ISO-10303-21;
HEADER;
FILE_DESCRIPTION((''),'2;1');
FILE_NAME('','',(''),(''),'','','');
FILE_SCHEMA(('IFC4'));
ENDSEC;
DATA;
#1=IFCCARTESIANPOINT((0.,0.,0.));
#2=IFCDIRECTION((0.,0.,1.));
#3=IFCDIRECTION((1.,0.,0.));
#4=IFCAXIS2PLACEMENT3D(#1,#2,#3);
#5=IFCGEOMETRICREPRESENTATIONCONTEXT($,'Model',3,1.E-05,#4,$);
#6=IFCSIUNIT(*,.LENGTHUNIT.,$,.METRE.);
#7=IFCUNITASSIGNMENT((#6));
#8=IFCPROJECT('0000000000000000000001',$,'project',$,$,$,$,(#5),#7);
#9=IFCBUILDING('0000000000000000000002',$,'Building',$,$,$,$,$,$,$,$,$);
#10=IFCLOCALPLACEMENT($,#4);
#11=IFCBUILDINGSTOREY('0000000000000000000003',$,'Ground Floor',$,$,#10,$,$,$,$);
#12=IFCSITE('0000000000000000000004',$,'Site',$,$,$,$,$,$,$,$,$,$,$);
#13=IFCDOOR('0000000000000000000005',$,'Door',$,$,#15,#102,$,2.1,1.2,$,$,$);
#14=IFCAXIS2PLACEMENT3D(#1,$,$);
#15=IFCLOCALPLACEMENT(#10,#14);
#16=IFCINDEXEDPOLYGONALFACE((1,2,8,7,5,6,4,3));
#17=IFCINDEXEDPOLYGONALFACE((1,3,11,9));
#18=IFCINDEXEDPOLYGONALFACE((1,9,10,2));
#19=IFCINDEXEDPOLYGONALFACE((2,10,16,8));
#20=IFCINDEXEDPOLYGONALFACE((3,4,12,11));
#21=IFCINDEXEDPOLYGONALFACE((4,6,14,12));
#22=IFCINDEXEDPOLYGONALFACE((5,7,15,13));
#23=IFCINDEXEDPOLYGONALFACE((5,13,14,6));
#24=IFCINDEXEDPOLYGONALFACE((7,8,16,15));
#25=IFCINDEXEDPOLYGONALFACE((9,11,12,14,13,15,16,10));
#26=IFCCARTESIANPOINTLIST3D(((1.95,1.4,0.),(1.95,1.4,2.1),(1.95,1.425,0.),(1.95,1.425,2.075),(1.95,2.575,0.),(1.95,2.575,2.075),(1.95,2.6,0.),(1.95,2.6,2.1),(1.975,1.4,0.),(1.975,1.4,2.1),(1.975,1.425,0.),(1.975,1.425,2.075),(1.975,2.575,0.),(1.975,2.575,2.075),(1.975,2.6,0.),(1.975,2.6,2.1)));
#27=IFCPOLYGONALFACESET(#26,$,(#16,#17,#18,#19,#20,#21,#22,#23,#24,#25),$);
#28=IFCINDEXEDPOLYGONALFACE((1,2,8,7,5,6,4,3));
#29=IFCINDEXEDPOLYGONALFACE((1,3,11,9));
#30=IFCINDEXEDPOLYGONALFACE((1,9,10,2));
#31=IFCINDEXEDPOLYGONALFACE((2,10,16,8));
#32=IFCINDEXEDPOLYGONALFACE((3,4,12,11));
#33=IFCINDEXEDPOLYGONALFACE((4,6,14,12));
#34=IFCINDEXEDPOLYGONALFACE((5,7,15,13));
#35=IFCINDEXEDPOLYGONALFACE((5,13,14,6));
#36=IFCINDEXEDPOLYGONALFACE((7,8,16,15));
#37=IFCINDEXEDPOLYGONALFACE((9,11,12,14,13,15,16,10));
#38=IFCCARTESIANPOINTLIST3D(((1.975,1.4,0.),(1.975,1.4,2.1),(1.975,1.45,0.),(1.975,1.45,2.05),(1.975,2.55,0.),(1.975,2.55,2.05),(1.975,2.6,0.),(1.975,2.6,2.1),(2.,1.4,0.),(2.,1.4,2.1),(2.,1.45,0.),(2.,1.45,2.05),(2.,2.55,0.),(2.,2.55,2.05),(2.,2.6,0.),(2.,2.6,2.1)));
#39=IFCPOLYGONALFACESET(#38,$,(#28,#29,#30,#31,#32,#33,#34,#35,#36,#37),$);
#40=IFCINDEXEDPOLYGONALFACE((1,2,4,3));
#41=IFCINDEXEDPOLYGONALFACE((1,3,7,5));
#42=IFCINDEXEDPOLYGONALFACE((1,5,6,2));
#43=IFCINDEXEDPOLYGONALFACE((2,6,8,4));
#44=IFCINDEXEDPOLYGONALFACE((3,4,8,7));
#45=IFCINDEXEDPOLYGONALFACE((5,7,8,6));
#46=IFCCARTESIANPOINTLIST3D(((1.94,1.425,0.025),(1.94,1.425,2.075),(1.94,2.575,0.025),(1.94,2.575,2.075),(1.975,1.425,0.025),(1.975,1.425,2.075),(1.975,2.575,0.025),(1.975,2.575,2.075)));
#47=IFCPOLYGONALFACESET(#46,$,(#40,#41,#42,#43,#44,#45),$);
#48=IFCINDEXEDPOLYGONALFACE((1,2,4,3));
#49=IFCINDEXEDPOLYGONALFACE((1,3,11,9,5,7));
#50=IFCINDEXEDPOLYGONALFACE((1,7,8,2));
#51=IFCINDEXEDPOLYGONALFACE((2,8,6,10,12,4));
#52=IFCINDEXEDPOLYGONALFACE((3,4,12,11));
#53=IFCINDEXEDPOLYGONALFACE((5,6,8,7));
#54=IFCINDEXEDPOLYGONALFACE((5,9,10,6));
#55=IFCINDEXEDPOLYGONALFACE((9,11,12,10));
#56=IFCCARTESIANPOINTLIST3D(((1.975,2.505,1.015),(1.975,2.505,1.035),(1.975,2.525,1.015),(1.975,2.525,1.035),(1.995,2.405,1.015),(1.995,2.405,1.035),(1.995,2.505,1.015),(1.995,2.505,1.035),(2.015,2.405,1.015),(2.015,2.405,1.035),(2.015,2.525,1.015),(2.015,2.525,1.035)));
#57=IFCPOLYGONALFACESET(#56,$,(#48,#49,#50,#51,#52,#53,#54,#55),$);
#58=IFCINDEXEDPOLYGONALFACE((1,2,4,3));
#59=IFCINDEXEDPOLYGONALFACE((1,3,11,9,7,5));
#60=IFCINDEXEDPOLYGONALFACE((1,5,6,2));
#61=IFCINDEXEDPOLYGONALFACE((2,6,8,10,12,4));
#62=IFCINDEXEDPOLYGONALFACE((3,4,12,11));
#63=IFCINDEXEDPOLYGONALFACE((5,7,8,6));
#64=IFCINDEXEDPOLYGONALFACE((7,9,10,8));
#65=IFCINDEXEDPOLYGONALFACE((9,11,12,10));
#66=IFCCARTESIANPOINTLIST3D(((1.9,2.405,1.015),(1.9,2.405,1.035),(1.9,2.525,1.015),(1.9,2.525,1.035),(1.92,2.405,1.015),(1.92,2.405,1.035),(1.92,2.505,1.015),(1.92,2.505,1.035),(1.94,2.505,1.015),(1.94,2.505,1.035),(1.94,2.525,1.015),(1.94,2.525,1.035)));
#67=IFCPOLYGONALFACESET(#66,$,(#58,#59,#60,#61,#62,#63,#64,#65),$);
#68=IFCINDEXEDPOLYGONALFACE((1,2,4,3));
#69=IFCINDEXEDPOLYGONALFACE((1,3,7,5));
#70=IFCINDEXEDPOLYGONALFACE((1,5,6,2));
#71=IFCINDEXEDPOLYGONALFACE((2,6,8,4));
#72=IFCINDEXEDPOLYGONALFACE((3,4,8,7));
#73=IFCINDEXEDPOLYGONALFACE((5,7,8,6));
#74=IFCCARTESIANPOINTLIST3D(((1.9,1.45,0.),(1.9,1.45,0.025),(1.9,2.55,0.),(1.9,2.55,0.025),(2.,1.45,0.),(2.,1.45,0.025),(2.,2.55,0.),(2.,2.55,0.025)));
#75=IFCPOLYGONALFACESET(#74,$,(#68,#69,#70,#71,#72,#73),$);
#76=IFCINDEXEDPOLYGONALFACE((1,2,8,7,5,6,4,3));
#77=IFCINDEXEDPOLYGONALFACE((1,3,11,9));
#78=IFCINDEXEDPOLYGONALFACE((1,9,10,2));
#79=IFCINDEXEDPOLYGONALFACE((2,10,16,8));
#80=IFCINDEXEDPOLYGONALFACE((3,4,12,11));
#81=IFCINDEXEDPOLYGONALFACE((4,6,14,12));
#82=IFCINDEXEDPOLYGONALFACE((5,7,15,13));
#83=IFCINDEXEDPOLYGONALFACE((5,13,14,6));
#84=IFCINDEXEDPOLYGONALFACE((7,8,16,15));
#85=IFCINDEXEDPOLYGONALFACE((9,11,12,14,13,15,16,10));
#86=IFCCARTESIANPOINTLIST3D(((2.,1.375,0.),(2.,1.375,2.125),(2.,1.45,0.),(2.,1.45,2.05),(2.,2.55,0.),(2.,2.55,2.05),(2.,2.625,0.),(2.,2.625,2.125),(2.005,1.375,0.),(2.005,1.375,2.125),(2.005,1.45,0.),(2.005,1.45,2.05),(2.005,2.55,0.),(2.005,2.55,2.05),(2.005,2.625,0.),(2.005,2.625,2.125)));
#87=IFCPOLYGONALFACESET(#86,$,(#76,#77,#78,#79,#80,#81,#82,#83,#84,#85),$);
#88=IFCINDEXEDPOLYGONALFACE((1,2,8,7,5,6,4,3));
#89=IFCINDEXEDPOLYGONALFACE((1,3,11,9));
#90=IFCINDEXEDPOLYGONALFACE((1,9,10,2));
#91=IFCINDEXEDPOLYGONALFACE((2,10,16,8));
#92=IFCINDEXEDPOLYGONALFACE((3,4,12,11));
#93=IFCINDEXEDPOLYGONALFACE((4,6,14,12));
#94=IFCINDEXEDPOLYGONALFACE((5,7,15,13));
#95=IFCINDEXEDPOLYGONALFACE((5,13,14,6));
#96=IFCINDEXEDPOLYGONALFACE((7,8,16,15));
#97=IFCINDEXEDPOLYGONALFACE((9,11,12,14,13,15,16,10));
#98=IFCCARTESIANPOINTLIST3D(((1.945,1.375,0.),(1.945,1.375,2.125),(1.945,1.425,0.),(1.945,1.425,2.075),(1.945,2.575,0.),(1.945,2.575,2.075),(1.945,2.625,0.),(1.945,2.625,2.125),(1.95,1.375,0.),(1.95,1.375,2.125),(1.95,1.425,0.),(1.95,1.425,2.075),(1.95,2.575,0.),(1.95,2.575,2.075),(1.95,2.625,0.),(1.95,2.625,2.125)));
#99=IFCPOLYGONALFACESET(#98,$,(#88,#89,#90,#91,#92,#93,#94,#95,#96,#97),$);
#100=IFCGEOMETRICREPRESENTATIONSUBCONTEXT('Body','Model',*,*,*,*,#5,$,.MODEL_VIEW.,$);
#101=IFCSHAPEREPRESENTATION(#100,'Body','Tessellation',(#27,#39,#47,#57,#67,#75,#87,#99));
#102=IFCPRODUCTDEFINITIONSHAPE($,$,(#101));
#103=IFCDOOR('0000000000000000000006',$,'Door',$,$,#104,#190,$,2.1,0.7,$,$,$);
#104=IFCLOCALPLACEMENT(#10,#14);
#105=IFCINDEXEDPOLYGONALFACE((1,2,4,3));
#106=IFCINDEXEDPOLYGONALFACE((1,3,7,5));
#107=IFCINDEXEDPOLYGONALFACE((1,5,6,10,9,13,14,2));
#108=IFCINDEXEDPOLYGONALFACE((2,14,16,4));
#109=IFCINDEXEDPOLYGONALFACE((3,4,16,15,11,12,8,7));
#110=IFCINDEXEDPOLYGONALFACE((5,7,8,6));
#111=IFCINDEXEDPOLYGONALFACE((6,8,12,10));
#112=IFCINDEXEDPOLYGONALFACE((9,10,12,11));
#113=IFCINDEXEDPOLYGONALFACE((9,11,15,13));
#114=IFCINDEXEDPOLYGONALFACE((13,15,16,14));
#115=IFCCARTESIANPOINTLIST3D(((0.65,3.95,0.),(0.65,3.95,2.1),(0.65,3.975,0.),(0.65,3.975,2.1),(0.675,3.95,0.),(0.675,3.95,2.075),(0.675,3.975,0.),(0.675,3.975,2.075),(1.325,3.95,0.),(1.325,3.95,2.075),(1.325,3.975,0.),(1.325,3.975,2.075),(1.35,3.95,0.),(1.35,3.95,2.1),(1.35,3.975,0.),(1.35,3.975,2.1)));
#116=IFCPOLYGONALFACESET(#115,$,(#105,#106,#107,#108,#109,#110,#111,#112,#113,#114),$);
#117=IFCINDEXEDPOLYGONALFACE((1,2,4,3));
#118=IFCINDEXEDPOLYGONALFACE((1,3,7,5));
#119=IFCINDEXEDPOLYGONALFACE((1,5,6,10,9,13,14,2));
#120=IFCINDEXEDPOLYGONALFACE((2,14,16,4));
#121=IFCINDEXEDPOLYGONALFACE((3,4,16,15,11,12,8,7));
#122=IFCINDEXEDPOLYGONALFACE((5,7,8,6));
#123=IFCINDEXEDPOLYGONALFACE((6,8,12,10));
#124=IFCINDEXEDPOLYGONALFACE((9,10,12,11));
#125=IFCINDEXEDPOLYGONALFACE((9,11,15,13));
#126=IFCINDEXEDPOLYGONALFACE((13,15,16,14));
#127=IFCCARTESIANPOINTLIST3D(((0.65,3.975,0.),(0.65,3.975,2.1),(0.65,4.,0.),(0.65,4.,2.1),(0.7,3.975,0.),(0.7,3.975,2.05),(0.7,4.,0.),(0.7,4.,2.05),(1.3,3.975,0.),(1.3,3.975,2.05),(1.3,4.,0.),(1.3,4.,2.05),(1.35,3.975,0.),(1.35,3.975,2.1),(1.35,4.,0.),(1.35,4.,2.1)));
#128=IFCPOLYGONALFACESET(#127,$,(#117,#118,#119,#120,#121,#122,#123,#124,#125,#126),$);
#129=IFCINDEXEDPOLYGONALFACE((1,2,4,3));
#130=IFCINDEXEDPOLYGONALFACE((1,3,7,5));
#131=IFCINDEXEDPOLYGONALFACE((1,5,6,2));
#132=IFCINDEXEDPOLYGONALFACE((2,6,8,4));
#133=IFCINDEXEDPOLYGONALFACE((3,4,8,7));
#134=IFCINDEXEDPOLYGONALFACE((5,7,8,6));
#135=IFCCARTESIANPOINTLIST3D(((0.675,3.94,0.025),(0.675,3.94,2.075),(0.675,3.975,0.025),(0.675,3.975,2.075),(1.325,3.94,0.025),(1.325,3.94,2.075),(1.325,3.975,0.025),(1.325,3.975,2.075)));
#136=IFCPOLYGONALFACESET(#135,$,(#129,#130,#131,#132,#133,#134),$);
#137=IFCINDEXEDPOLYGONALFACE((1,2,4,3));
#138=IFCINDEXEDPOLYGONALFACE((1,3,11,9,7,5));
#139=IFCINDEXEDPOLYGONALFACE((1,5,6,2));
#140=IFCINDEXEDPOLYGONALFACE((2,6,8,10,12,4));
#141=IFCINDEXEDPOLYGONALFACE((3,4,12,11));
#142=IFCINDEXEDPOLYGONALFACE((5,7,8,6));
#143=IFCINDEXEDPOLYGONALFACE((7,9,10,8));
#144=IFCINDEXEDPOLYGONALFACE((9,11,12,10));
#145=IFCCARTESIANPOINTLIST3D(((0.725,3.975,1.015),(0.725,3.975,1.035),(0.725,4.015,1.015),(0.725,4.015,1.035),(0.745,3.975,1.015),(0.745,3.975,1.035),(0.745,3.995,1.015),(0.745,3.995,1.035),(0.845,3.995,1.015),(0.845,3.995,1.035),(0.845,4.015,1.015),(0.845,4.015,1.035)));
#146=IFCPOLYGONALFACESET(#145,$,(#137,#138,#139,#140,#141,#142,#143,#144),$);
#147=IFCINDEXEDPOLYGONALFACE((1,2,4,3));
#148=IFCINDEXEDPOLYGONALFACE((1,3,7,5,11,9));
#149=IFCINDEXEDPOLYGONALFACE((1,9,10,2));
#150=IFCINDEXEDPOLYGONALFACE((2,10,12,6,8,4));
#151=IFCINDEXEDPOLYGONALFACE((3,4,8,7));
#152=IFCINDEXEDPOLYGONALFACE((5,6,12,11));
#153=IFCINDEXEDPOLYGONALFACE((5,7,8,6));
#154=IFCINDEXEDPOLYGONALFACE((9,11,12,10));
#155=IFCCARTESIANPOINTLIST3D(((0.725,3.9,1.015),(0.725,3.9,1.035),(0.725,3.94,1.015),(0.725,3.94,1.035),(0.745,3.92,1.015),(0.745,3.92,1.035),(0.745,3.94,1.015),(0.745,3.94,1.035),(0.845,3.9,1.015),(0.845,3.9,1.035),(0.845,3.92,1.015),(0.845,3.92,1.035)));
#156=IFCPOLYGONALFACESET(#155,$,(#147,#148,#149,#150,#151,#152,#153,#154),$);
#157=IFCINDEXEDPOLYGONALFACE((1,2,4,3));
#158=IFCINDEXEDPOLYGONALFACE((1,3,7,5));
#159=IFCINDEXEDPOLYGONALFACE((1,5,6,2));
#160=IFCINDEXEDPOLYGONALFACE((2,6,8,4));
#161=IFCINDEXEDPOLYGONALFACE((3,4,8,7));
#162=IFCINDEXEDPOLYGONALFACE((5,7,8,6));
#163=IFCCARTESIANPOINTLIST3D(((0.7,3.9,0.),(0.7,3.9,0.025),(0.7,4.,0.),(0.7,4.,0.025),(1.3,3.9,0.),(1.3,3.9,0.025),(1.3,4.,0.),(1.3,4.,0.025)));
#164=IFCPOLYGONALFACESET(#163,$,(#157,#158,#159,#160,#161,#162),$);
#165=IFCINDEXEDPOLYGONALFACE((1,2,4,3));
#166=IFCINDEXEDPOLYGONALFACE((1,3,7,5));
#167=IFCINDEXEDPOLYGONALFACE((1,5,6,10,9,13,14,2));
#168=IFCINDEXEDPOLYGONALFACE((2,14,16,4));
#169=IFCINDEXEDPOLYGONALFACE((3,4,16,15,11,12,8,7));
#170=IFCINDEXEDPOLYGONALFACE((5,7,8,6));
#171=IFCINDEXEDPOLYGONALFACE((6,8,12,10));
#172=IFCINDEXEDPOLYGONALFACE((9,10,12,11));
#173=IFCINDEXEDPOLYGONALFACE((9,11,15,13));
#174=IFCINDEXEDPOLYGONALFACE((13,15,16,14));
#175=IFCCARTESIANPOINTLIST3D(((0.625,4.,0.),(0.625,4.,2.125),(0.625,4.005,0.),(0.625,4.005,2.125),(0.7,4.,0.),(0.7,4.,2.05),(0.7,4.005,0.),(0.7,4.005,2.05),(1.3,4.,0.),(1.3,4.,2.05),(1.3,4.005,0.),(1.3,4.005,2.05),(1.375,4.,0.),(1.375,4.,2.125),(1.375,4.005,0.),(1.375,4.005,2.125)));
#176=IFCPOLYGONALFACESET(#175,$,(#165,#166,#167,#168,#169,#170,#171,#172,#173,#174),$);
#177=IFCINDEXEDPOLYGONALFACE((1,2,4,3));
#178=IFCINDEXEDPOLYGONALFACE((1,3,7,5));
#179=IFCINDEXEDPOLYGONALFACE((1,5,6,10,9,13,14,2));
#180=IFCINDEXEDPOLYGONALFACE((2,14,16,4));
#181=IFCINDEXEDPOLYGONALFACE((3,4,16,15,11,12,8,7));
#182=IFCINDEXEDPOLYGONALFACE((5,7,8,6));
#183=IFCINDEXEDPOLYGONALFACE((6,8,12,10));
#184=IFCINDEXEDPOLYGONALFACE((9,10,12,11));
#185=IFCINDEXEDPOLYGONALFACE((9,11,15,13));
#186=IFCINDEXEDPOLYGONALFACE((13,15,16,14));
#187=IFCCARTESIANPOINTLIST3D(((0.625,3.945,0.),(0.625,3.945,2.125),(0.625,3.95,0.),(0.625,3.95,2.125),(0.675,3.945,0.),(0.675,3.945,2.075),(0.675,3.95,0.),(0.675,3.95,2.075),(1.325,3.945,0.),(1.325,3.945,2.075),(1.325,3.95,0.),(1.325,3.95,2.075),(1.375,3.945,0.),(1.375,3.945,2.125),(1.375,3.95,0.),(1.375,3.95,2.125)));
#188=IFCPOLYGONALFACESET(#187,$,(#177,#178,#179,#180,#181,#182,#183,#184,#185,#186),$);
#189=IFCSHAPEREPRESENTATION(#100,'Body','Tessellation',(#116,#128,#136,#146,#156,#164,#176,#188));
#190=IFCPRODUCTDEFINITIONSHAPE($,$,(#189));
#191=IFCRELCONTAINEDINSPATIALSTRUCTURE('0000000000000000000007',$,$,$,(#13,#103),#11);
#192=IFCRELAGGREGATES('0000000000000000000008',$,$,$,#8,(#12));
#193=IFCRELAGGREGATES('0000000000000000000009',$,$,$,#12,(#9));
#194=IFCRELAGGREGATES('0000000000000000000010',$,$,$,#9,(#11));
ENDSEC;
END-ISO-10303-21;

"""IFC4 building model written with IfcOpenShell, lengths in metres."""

from ifc_helpers import new_model, si_unit, frame, origin_with_axes, place, context, subcontext, project, spatial, line, indexed_curve, outline, extrude, element, save


model = new_model("IFC4")

# Units and contexts
model_context = context("Model", 3, precision=1e-05, world=origin_with_axes())
body_context = subcontext(model_context, "Body", "Model", "MODEL_VIEW")
ifc_project = project(units=[si_unit("LENGTHUNIT", "METRE")], contexts=[model_context])

# Site, building, storey
site = spatial("IfcSite", under=ifc_project, Name="Site")
building = spatial("IfcBuilding", under=site, Name="Building")
storey_placement = place(None, origin_with_axes())
storey = spatial("IfcBuildingStorey", under=building, at=storey_placement, Name="Ground Floor")

# Doors
door_1_placement = place(storey_placement, frame((2.0, 1.4, 0.0), z_axis=(0.0, 0.0, 1.0), x_axis=(0.0, 1.0, 0.0)))
element("IfcDoor", 1, at=door_1_placement, inside=storey, Name="Door", OverallHeight=2.1, OverallWidth=1.2, context=body_context, shape_type="SweptSolid", body=[
    extrude(outline(indexed_curve([(0.0, 0.0), (0.0, 2.1), (1.2, 2.1), (1.2, 0.0), (1.175, 0.0), (1.175, 2.075), (0.025, 2.075), (0.025, 0.0)], segments=[line(1, 2, 3, 4, 5, 6, 7, 8, 1)])), frame((0.0, 0.025, 0.0), z_axis=(0.0, -1.0, 0.0), x_axis=(1.0, 0.0, 0.0)), (0.0, 0.0, -1.0), 0.025),
    extrude(outline(indexed_curve([(0.0, 0.0), (0.0, 2.1), (1.2, 2.1), (1.2, 0.0), (1.15, 0.0), (1.15, 2.05), (0.05, 2.05), (0.05, 0.0)], segments=[line(1, 2, 3, 4, 5, 6, 7, 8, 1)])), frame((0.0, 0.0, 0.0), z_axis=(0.0, -1.0, 0.0), x_axis=(1.0, 0.0, 0.0)), (0.0, 0.0, -1.0), 0.025),
    extrude(outline(indexed_curve([(0.0, 0.0), (1.15, 0.0), (1.15, 0.035), (0.0, 0.035)], segments=[line(1, 2, 3, 4, 1)])), frame((0.025, 0.025, 0.025), z_axis=(0.0, 0.0, 1.0), x_axis=(1.0, 0.0, 0.0)), (0.0, 0.0, 1.0), 2.05),
    extrude(outline(indexed_curve([(0.0, 0.0), (0.0, -0.04), (-0.12, -0.04), (-0.12, -0.02), (-0.02, -0.02), (-0.02, 0.0)], segments=[line(1, 2, 3, 4, 5, 6, 1)])), frame((1.125, 0.025, 1.015), z_axis=(0.0, 0.0, 1.0), x_axis=(1.0, 0.0, 0.0)), (0.0, 0.0, 1.0), 0.02),
    extrude(outline(indexed_curve([(0.0, 0.0), (0.0, 0.04), (-0.12, 0.04), (-0.12, 0.02), (-0.02, 0.02), (-0.02, 0.0)], segments=[line(1, 2, 3, 4, 5, 6, 1)])), frame((1.125, 0.06, 1.015), z_axis=(0.0, 0.0, 1.0), x_axis=(1.0, 0.0, 0.0)), (0.0, 0.0, 1.0), 0.02),
    extrude(outline(indexed_curve([(0.0, 0.0), (1.1, 0.0), (1.1, 0.1), (0.0, 0.1)], segments=[line(1, 2, 3, 4, 1)])), frame((0.05, 0.0, 0.0), z_axis=(0.0, 0.0, 1.0), x_axis=(1.0, 0.0, 0.0)), (0.0, 0.0, 1.0), 0.025),
    extrude(outline(indexed_curve([(0.0, 0.0), (0.0, 2.125), (1.25, 2.125), (1.25, 0.0), (1.175, 0.0), (1.175, 2.05), (0.075, 2.05), (0.075, 0.0)], segments=[line(1, 2, 3, 4, 5, 6, 7, 8, 1)])), frame((-0.025, -0.005, 0.0), z_axis=(0.0, -1.0, 0.0), x_axis=(1.0, 0.0, 0.0)), (0.0, 0.0, -1.0), 0.005),
    extrude(outline(indexed_curve([(0.0, 0.0), (0.0, 2.125), (1.25, 2.125), (1.25, 0.0), (1.2, 0.0), (1.2, 2.075), (0.05, 2.075), (0.05, 0.0)], segments=[line(1, 2, 3, 4, 5, 6, 7, 8, 1)])), frame((-0.025, 0.05, 0.0), z_axis=(0.0, -1.0, 0.0), x_axis=(1.0, 0.0, 0.0)), (0.0, 0.0, -1.0), 0.005),
])
door_2_placement = place(storey_placement, frame((1.35, 4.0, 0.0), z_axis=(0.0, 0.0, 1.0), x_axis=(-1.0, 0.0, 0.0)))
element("IfcDoor", 2, at=door_2_placement, inside=storey, Name="Door", OverallHeight=2.1, OverallWidth=0.7, context=body_context, shape_type="SweptSolid", body=[
    extrude(outline(indexed_curve([(0.0, 0.0), (0.0, 2.1), (0.7, 2.1), (0.7, 0.0), (0.675, 0.0), (0.675, 2.075), (0.025, 2.075), (0.025, 0.0)], segments=[line(1, 2, 3, 4, 5, 6, 7, 8, 1)])), frame((0.0, 0.025, 0.0), z_axis=(0.0, -1.0, 0.0), x_axis=(1.0, 0.0, 0.0)), (0.0, 0.0, -1.0), 0.025),
    extrude(outline(indexed_curve([(0.0, 0.0), (0.0, 2.1), (0.7, 2.1), (0.7, 0.0), (0.65, 0.0), (0.65, 2.05), (0.05, 2.05), (0.05, 0.0)], segments=[line(1, 2, 3, 4, 5, 6, 7, 8, 1)])), frame((0.0, 0.0, 0.0), z_axis=(0.0, -1.0, 0.0), x_axis=(1.0, 0.0, 0.0)), (0.0, 0.0, -1.0), 0.025),
    extrude(outline(indexed_curve([(0.0, 0.0), (0.65, 0.0), (0.65, 0.035), (0.0, 0.035)], segments=[line(1, 2, 3, 4, 1)])), frame((0.025, 0.025, 0.025), z_axis=(0.0, 0.0, 1.0), x_axis=(1.0, 0.0, 0.0)), (0.0, 0.0, 1.0), 2.05),
    extrude(outline(indexed_curve([(0.0, 0.0), (0.0, -0.04), (-0.12, -0.04), (-0.12, -0.02), (-0.02, -0.02), (-0.02, 0.0)], segments=[line(1, 2, 3, 4, 5, 6, 1)])), frame((0.625, 0.025, 1.015), z_axis=(0.0, 0.0, 1.0), x_axis=(1.0, 0.0, 0.0)), (0.0, 0.0, 1.0), 0.02),
    extrude(outline(indexed_curve([(0.0, 0.0), (0.0, 0.04), (-0.12, 0.04), (-0.12, 0.02), (-0.02, 0.02), (-0.02, 0.0)], segments=[line(1, 2, 3, 4, 5, 6, 1)])), frame((0.625, 0.06, 1.015), z_axis=(0.0, 0.0, 1.0), x_axis=(1.0, 0.0, 0.0)), (0.0, 0.0, 1.0), 0.02),
    extrude(outline(indexed_curve([(0.0, 0.0), (0.6, 0.0), (0.6, 0.1), (0.0, 0.1)], segments=[line(1, 2, 3, 4, 1)])), frame((0.05, 0.0, 0.0), z_axis=(0.0, 0.0, 1.0), x_axis=(1.0, 0.0, 0.0)), (0.0, 0.0, 1.0), 0.025),
    extrude(outline(indexed_curve([(0.0, 0.0), (0.0, 2.125), (0.75, 2.125), (0.75, 0.0), (0.675, 0.0), (0.675, 2.05), (0.075, 2.05), (0.075, 0.0)], segments=[line(1, 2, 3, 4, 5, 6, 7, 8, 1)])), frame((-0.025, -0.005, 0.0), z_axis=(0.0, -1.0, 0.0), x_axis=(1.0, 0.0, 0.0)), (0.0, 0.0, -1.0), 0.005),
    extrude(outline(indexed_curve([(0.0, 0.0), (0.0, 2.125), (0.75, 2.125), (0.75, 0.0), (0.7, 0.0), (0.7, 2.075), (0.05, 2.075), (0.05, 0.0)], segments=[line(1, 2, 3, 4, 5, 6, 7, 8, 1)])), frame((-0.025, 0.05, 0.0), z_axis=(0.0, -1.0, 0.0), x_axis=(1.0, 0.0, 0.0)), (0.0, 0.0, -1.0), 0.005),
])

save(model, "model.ifc")
